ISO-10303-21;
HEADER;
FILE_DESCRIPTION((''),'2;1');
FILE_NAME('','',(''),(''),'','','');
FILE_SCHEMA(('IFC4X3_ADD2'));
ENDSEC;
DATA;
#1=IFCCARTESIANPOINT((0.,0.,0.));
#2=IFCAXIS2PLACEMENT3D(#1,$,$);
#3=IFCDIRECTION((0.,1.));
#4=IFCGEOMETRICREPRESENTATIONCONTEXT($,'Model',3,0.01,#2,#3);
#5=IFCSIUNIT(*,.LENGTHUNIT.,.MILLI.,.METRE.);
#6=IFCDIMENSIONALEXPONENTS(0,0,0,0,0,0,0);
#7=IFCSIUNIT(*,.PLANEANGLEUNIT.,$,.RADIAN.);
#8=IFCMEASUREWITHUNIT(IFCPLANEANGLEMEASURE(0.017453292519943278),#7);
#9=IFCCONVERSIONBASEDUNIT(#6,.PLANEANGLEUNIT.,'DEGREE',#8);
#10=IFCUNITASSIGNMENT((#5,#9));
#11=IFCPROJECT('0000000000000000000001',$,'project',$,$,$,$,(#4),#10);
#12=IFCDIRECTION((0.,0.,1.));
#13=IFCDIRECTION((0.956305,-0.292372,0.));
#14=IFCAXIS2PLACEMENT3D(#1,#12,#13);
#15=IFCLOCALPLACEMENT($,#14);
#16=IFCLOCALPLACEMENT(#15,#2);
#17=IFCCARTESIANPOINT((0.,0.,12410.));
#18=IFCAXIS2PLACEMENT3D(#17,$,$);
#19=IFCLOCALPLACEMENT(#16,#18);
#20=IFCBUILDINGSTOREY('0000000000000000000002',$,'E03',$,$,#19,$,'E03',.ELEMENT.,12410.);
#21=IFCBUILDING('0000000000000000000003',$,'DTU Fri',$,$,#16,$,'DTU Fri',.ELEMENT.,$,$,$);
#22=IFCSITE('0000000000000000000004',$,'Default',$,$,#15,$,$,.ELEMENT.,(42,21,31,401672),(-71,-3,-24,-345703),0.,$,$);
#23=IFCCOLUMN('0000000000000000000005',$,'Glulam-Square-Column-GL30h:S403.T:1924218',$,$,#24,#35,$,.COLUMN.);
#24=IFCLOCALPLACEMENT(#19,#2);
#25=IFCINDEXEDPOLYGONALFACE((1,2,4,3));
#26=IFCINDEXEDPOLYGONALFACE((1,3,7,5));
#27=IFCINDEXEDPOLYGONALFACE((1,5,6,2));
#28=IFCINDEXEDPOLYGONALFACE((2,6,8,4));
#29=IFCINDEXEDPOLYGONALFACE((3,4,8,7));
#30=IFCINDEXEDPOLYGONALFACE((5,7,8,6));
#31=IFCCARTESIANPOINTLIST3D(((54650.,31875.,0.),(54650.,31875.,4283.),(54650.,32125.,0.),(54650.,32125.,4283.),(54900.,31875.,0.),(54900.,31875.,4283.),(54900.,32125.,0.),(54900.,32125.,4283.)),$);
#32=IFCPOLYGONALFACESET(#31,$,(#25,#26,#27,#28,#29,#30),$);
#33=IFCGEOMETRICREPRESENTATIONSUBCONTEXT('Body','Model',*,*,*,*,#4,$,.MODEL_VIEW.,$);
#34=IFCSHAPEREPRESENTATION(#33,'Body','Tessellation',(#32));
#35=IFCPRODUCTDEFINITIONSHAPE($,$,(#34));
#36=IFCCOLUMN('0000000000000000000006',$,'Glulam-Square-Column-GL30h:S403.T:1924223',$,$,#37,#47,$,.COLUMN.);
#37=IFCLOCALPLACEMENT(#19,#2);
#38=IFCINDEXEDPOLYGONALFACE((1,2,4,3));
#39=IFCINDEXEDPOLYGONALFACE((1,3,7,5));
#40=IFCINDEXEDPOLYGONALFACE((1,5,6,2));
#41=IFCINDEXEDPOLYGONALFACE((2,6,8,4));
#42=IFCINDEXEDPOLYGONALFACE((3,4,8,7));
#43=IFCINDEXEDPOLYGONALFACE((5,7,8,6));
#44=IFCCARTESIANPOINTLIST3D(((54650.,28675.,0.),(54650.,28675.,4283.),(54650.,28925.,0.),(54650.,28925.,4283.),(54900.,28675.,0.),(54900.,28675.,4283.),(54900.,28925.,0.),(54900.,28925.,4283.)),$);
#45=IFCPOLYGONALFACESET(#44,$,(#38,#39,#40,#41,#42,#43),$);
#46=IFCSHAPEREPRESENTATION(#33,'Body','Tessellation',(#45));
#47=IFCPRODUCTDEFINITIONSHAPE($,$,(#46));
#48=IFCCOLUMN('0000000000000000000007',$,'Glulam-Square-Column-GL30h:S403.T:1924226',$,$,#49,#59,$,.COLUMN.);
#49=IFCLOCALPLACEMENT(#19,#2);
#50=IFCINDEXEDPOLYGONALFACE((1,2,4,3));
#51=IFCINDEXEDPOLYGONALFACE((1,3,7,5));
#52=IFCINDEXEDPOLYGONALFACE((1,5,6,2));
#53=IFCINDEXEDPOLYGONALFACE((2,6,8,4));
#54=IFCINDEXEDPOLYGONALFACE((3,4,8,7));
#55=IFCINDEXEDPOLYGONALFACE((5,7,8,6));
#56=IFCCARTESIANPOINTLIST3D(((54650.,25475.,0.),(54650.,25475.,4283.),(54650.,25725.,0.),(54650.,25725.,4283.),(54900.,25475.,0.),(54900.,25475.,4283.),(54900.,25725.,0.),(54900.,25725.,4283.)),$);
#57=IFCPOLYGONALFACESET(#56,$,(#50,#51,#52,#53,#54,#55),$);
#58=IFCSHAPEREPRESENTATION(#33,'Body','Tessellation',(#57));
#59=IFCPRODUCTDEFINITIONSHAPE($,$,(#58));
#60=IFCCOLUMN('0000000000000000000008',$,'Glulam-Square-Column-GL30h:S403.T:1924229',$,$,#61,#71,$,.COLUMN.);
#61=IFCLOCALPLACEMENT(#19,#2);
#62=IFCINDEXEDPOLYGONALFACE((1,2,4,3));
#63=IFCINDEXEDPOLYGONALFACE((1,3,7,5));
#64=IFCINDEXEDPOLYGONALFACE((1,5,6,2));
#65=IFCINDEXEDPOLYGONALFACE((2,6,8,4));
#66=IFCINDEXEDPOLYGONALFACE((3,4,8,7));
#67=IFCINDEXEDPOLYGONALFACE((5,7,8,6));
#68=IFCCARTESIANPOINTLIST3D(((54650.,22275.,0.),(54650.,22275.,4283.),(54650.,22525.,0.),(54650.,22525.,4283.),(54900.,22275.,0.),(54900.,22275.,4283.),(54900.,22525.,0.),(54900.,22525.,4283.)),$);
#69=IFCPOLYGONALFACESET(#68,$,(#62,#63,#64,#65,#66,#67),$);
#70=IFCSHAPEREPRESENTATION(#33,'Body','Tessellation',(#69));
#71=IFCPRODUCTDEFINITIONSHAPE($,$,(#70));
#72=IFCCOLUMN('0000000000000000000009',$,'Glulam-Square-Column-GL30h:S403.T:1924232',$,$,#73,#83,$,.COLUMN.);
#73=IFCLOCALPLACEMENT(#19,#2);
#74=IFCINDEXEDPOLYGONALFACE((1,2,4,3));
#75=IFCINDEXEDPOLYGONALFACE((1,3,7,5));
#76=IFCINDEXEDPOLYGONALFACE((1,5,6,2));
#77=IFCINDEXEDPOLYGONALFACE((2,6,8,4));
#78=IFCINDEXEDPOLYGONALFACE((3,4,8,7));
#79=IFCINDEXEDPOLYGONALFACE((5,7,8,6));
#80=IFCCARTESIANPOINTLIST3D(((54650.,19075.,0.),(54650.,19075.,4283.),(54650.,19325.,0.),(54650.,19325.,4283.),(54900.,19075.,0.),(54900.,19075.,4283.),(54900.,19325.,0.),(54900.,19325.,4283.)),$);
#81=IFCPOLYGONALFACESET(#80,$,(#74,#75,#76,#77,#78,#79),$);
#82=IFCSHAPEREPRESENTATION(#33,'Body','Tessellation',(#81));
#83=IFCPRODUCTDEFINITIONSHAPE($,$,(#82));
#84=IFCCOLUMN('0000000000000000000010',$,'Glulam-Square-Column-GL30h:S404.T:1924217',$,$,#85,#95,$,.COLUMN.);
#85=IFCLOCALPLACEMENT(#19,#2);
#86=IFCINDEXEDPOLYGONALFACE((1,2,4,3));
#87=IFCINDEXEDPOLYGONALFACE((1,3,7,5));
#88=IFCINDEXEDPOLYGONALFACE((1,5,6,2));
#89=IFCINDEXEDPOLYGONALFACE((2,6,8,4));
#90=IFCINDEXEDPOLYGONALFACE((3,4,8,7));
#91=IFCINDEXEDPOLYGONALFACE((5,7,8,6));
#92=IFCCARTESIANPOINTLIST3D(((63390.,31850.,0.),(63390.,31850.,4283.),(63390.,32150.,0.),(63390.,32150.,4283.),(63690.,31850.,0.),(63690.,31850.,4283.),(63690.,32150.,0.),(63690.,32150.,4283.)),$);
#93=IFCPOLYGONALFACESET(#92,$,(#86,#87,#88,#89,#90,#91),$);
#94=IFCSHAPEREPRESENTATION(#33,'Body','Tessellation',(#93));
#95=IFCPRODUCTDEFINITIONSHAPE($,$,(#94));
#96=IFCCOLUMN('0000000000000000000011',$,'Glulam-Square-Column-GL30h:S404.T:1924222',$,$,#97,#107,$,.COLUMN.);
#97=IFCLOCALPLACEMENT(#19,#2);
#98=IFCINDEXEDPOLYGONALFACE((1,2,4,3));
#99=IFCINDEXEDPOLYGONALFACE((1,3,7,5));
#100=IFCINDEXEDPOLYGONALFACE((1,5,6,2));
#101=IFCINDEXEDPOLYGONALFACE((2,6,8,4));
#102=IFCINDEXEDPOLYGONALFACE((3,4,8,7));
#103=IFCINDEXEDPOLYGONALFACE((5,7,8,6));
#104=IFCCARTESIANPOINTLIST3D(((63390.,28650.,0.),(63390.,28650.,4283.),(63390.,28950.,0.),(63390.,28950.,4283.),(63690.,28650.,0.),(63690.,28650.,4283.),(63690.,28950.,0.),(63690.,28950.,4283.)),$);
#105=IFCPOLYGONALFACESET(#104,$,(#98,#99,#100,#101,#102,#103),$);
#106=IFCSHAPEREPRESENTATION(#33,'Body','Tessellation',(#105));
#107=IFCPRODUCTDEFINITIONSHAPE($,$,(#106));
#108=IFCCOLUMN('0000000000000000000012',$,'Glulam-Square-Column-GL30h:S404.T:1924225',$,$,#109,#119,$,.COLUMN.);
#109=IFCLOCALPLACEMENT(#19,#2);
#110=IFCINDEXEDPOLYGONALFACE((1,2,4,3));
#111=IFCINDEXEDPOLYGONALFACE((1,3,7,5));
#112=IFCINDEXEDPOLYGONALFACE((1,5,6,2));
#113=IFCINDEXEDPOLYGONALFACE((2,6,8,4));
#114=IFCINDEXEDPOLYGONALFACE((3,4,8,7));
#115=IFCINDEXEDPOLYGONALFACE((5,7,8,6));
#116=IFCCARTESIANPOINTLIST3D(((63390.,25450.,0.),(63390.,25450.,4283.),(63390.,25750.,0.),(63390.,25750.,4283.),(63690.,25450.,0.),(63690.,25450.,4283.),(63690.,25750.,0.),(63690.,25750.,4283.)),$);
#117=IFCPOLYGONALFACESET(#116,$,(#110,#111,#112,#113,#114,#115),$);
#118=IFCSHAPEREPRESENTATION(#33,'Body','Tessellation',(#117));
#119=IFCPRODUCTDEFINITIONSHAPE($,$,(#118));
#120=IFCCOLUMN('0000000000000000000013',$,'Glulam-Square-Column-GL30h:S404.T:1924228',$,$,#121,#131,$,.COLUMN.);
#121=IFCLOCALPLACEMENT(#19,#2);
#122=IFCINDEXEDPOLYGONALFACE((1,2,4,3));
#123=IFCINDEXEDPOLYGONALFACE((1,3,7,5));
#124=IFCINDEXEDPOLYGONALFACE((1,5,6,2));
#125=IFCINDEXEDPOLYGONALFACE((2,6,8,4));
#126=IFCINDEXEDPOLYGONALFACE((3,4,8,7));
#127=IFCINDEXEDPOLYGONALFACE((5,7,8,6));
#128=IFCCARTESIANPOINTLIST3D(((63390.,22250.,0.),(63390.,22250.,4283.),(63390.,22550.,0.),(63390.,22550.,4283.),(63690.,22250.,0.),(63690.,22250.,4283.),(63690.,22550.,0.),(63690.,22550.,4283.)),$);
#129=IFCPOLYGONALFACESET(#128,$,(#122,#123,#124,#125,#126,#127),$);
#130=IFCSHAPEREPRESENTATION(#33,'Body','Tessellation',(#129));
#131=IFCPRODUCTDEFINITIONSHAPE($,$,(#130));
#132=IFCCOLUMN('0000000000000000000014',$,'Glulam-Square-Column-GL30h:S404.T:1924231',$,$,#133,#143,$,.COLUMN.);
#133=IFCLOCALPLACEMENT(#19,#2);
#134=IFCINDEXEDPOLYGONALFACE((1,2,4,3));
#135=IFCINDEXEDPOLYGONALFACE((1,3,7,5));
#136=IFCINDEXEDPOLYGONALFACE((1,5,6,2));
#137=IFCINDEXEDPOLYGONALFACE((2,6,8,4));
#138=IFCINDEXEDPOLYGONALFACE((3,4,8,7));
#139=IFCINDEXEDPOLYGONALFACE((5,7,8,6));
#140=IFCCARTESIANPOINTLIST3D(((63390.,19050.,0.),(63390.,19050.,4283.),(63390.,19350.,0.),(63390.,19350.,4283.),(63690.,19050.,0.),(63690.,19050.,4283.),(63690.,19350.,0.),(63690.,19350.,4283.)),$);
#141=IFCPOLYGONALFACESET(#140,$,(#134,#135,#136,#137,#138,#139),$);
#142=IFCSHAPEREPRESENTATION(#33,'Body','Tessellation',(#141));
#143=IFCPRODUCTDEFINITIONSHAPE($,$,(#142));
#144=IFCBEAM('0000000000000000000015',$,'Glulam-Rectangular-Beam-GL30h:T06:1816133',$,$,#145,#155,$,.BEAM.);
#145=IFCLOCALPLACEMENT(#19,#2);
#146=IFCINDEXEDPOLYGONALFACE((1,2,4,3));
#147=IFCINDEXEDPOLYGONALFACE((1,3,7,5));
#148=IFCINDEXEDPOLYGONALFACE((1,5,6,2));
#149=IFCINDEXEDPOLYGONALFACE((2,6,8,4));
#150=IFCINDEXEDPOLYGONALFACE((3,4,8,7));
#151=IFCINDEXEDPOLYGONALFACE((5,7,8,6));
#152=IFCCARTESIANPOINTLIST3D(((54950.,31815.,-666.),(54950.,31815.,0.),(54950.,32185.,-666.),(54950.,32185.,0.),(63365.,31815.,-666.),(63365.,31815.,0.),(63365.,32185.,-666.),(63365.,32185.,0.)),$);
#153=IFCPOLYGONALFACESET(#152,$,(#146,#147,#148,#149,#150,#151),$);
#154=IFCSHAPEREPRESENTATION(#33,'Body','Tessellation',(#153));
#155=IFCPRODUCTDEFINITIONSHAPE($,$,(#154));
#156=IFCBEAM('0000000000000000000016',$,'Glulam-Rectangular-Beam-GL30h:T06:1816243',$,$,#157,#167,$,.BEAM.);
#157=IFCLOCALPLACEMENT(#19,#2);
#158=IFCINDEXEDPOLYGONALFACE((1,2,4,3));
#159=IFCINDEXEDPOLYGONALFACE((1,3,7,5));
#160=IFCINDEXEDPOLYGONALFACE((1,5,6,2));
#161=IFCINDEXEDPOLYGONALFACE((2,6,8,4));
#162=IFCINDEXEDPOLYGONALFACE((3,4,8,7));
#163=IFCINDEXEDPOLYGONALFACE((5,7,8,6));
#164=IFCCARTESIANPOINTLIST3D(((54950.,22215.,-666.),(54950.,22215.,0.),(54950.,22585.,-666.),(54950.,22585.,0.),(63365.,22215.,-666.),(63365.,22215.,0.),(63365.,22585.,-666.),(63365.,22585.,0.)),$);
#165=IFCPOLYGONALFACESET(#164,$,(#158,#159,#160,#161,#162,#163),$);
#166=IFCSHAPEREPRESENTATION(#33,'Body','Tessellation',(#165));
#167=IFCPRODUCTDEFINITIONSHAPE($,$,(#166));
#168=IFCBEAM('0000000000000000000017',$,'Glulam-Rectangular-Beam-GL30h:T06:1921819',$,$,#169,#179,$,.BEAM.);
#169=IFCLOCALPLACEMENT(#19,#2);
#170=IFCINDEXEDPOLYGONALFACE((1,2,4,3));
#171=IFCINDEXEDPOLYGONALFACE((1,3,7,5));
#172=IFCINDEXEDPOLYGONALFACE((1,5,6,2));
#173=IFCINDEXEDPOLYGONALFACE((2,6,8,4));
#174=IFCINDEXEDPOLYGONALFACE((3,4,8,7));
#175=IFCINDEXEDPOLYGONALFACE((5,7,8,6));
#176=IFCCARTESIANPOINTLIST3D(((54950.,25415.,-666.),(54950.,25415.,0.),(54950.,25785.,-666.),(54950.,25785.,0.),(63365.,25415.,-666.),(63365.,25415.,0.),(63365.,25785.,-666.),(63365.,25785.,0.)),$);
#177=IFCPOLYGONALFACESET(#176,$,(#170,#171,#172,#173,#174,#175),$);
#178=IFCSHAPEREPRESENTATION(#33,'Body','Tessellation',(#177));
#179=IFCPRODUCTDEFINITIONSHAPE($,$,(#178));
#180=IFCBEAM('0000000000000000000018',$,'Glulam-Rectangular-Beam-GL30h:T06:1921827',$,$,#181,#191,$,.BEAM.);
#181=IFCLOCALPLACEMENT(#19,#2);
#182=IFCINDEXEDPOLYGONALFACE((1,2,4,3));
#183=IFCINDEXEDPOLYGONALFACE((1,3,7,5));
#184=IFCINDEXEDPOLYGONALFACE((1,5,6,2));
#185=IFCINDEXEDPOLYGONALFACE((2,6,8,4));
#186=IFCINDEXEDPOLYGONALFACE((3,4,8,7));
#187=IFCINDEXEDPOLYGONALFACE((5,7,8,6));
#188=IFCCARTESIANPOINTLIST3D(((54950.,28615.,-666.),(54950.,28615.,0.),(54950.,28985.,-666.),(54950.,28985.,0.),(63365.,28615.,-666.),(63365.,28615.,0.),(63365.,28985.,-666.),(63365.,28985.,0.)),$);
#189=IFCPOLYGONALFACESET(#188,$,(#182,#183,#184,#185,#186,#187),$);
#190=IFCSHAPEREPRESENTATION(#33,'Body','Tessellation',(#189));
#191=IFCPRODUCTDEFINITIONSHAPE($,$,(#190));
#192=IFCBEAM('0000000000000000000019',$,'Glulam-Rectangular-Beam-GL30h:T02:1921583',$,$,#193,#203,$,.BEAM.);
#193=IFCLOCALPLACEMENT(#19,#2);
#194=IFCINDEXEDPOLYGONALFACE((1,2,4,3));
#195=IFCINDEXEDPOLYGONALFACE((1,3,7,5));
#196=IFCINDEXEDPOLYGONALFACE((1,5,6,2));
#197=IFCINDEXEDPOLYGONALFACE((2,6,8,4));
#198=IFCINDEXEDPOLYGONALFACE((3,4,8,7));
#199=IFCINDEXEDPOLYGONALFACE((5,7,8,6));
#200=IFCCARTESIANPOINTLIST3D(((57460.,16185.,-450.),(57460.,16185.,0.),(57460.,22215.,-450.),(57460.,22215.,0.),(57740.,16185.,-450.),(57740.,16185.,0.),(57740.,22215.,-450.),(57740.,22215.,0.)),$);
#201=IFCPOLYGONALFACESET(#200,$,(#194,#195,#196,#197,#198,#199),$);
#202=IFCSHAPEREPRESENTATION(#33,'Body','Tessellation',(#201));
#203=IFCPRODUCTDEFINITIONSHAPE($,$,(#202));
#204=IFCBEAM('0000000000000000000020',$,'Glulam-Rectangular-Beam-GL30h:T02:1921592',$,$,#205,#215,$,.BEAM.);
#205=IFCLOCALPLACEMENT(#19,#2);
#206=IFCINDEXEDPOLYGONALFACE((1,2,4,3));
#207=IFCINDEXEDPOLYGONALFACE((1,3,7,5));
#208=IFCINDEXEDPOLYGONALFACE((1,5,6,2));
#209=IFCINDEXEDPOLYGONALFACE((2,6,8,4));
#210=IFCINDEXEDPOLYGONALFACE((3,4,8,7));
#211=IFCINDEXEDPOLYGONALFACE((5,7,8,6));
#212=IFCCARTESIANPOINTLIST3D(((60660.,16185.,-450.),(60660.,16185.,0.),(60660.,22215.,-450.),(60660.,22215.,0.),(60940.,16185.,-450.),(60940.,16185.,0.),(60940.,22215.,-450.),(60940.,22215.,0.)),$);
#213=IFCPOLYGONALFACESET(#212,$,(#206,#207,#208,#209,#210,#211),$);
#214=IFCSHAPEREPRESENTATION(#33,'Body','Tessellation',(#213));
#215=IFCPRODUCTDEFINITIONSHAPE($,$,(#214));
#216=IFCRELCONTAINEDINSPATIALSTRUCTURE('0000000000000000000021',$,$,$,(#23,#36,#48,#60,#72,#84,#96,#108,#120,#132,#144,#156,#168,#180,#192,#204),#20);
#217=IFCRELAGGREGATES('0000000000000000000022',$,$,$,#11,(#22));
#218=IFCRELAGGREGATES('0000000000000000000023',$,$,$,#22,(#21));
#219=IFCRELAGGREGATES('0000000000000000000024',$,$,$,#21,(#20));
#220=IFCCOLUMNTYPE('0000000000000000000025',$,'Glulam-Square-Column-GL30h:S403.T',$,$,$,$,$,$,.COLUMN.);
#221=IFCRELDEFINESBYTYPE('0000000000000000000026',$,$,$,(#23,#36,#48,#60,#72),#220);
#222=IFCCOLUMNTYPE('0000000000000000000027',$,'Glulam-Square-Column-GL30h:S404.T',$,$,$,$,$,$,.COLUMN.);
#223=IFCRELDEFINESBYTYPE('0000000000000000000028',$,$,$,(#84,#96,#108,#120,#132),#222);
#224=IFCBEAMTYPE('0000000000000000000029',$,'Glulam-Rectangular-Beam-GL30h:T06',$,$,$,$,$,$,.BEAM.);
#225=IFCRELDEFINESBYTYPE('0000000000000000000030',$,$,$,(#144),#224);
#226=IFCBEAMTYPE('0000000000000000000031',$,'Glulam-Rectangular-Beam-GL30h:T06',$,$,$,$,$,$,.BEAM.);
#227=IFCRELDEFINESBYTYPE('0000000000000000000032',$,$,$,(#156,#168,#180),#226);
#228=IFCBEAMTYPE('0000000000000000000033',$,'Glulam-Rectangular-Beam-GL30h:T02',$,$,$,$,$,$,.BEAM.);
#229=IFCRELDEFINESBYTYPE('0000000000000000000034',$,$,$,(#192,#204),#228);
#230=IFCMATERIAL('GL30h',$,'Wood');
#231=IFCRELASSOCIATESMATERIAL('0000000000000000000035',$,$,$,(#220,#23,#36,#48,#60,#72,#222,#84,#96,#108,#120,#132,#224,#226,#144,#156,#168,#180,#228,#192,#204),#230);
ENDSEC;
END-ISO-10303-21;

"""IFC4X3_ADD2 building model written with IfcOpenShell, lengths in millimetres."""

from ifc_helpers import new_model, entity, si_unit, converted_unit, direction, frame, origin, origin_2d_with_axis, place, context, subcontext, project, spatial, rectangle, extrude, source, transform, mapped, material, material_profile, profile_set, profile_usage, type_object, type_shapes, element, save


model = new_model("IFC4X3_ADD2")

# Units and contexts
model_context = context("Model", 3, precision=0.01, world=origin(), true_north=direction((0.0, 1.0)))
body_context = subcontext(model_context, "Body", "Model", "MODEL_VIEW")
ifc_project = project(units=[si_unit("LENGTHUNIT", "METRE", prefix="MILLI"), converted_unit("PLANEANGLEUNIT", "DEGREE", entity("IfcPlaneAngleMeasure", 0.017453292519943278), si_unit("PLANEANGLEUNIT", "RADIAN"), dimensions=[0, 0, 0, 0, 0, 0, 0])], contexts=[model_context])

# Site, building, storey
site_placement = place(None, frame((0.0, 0.0, 0.0), z_axis=(0.0, 0.0, 1.0), x_axis=(0.956305, -0.292372, 0.0)))
site = spatial("IfcSite", under=ifc_project, at=site_placement, Name="Default", CompositionType="ELEMENT", RefLatitude=(42, 21, 31, 401672), RefLongitude=(-71, -3, -24, -345703), RefElevation=0.0)
building_placement = place(site_placement, origin())
building = spatial("IfcBuilding", under=site, at=building_placement, Name="DTU Fri", LongName="DTU Fri", CompositionType="ELEMENT")
storey_placement = place(building_placement, frame((0.0, 0.0, 12410.0)))
storey = spatial("IfcBuildingStorey", under=building, at=storey_placement, Name="E03", LongName="E03", CompositionType="ELEMENT", Elevation=12410.0)

# Columns
ifc_material_1 = material(Name="GL30h", Category="Wood")
ifc_material_profile_1 = material_profile(ifc_material_1, rectangle(XDim=250.0, YDim=250.0, at=origin_2d_with_axis()), Name="S403.T")
ifc_profile_set_1 = profile_set([ifc_material_profile_1], Name="S403.T")
ifc_profile_usage_1 = profile_usage(ifc_profile_set_1)
column_type_1 = type_object("IfcColumnType", Name="Glulam-Square-Column-GL30h:S403.T", PredefinedType="COLUMN", material=ifc_profile_set_1)
shared_shape_1 = source(origin(), body_context, "Body", "SweptSolid", [
    extrude(rectangle(XDim=250.0, YDim=250.0, at=origin_2d_with_axis()), frame((0.0, 0.0, 12410.0), z_axis=(0.0, 0.0, 1.0), x_axis=(0.0, 1.0, 0.0)), (0.0, 0.0, 1.0), 4283.0),
])
type_shapes(column_type_1, [shared_shape_1])
for number, where, name in (
    (1, (54775.0, 32000.0, -12410.0), "Glulam-Square-Column-GL30h:S403.T:1924218"),
    (2, (54775.0, 28800.0, -12410.0), "Glulam-Square-Column-GL30h:S403.T:1924223"),
    (3, (54775.0, 25600.0, -12410.0), "Glulam-Square-Column-GL30h:S403.T:1924226"),
    (4, (54775.0, 22400.0, -12410.0), "Glulam-Square-Column-GL30h:S403.T:1924229"),
    (5, (54775.0, 19200.0, -12410.0), "Glulam-Square-Column-GL30h:S403.T:1924232"),
):
    element("IfcColumn", number, at=place(storey_placement, frame(where)), inside=storey, type_object=column_type_1, material=ifc_profile_usage_1, Name=name, PredefinedType="COLUMN", context=body_context, shape_type="MappedRepresentation", body=[
        mapped(shared_shape_1, transform((0.0, 0.0, 0.0), scale=1.0)),
    ])
ifc_material_profile_2 = material_profile(ifc_material_1, rectangle(XDim=300.0, YDim=300.0, at=origin_2d_with_axis()), Name="S404.T")
ifc_profile_set_2 = profile_set([ifc_material_profile_2], Name="S404.T")
ifc_profile_usage_2 = profile_usage(ifc_profile_set_2)
column_type_2 = type_object("IfcColumnType", Name="Glulam-Square-Column-GL30h:S404.T", PredefinedType="COLUMN", material=ifc_profile_set_2)
shared_shape_2 = source(origin(), body_context, "Body", "SweptSolid", [
    extrude(rectangle(XDim=300.0, YDim=300.0, at=origin_2d_with_axis()), frame((0.0, 0.0, 12410.0), z_axis=(0.0, 0.0, 1.0), x_axis=(0.0, 1.0, 0.0)), (0.0, 0.0, 1.0), 4283.0),
])
type_shapes(column_type_2, [shared_shape_2])
for number, where, name in (
    (6, (63540.0, 32000.0, -12410.0), "Glulam-Square-Column-GL30h:S404.T:1924217"),
    (7, (63540.0, 28800.0, -12410.0), "Glulam-Square-Column-GL30h:S404.T:1924222"),
    (8, (63540.0, 25600.0, -12410.0), "Glulam-Square-Column-GL30h:S404.T:1924225"),
    (9, (63540.0, 22400.0, -12410.0), "Glulam-Square-Column-GL30h:S404.T:1924228"),
    (10, (63540.0, 19200.0, -12410.0), "Glulam-Square-Column-GL30h:S404.T:1924231"),
):
    element("IfcColumn", number, at=place(storey_placement, frame(where)), inside=storey, type_object=column_type_2, material=ifc_profile_usage_2, Name=name, PredefinedType="COLUMN", context=body_context, shape_type="MappedRepresentation", body=[
        mapped(shared_shape_2, transform((0.0, 0.0, 0.0), scale=1.0)),
    ])

# Beams
ifc_material_profile_3 = material_profile(ifc_material_1, rectangle(XDim=666.0, YDim=370.0, at=origin_2d_with_axis()), Name="T06")
ifc_profile_set_3 = profile_set([ifc_material_profile_3], Name="T06")
ifc_profile_usage_3 = profile_usage(ifc_profile_set_3, cardinal=8)
beam_type_1 = type_object("IfcBeamType", Name="Glulam-Rectangular-Beam-GL30h:T06", PredefinedType="BEAM", material=ifc_profile_set_3)
shared_shape_3 = source(origin(), body_context, "Body", "SweptSolid", [
    extrude(rectangle(XDim=666.0, YDim=370.0, at=origin_2d_with_axis()), frame((-4137.5, 0.0, 0.0), z_axis=(1.0, 0.0, 0.0), x_axis=(0.0, 0.0, -1.0)), (0.0, 0.0, 1.0), 8415.0),
])
type_shapes(beam_type_1, [shared_shape_3])
beam_1_placement = place(storey_placement, frame((59087.5, 32000.0, -333.0)))
element("IfcBeam", 11, at=beam_1_placement, inside=storey, type_object=beam_type_1, material=ifc_profile_usage_3, Name="Glulam-Rectangular-Beam-GL30h:T06:1816133", PredefinedType="BEAM", context=body_context, shape_type="MappedRepresentation", body=[
    mapped(shared_shape_3, transform((0.0, 0.0, 0.0), scale=1.0)),
])
beam_type_2 = type_object("IfcBeamType", Name="Glulam-Rectangular-Beam-GL30h:T06", PredefinedType="BEAM", material=ifc_profile_set_3)
shared_shape_4 = source(origin(), body_context, "Body", "SweptSolid", [
    extrude(rectangle(XDim=666.0, YDim=370.0, at=origin_2d_with_axis()), frame((-4150.0, 0.0, 0.0), z_axis=(1.0, 0.0, 0.0), x_axis=(0.0, 0.0, -1.0)), (0.0, 0.0, 1.0), 8415.0),
])
type_shapes(beam_type_2, [shared_shape_4])
for number, where, name in (
    (12, (59100.0, 22400.0, -333.0), "Glulam-Rectangular-Beam-GL30h:T06:1816243"),
    (13, (59100.0, 25600.0, -333.0), "Glulam-Rectangular-Beam-GL30h:T06:1921819"),
    (14, (59100.0, 28800.0, -333.0), "Glulam-Rectangular-Beam-GL30h:T06:1921827"),
):
    element("IfcBeam", number, at=place(storey_placement, frame(where)), inside=storey, type_object=beam_type_2, material=ifc_profile_usage_3, Name=name, PredefinedType="BEAM", context=body_context, shape_type="MappedRepresentation", body=[
        mapped(shared_shape_4, transform((0.0, 0.0, 0.0), scale=1.0)),
    ])
ifc_material_profile_4 = material_profile(ifc_material_1, rectangle(XDim=450.0, YDim=280.0, at=origin_2d_with_axis()), Name="T02")
ifc_profile_set_4 = profile_set([ifc_material_profile_4], Name="T02")
ifc_profile_usage_4 = profile_usage(ifc_profile_set_4, cardinal=8)
beam_type_3 = type_object("IfcBeamType", Name="Glulam-Rectangular-Beam-GL30h:T02", PredefinedType="BEAM", material=ifc_profile_set_4)
shared_shape_5 = source(origin(), body_context, "Body", "SweptSolid", [
    extrude(rectangle(XDim=450.0, YDim=280.0, at=origin_2d_with_axis()), frame((-3015.0, 0.0, 0.0), z_axis=(1.0, 0.0, 0.0), x_axis=(0.0, 0.0, -1.0)), (0.0, 0.0, 1.0), 6030.0),
])
type_shapes(beam_type_3, [shared_shape_5])
for number, where, z_axis, x_axis, name in (
    (15, (57600.0, 19200.0, -225.0), (0.0, 0.0, 1.0), (0.0, 1.0, 0.0), "Glulam-Rectangular-Beam-GL30h:T02:1921583"),
    (16, (60800.0, 19200.0, -225.0), (0.0, 0.0, 1.0), (0.0, 1.0, 0.0), "Glulam-Rectangular-Beam-GL30h:T02:1921592"),
):
    element("IfcBeam", number, at=place(storey_placement, frame(where, z_axis=z_axis, x_axis=x_axis)), inside=storey, type_object=beam_type_3, material=ifc_profile_usage_4, Name=name, PredefinedType="BEAM", context=body_context, shape_type="MappedRepresentation", body=[
        mapped(shared_shape_5, transform((0.0, 0.0, 0.0), scale=1.0)),
    ])

save(model, "model.ifc")
